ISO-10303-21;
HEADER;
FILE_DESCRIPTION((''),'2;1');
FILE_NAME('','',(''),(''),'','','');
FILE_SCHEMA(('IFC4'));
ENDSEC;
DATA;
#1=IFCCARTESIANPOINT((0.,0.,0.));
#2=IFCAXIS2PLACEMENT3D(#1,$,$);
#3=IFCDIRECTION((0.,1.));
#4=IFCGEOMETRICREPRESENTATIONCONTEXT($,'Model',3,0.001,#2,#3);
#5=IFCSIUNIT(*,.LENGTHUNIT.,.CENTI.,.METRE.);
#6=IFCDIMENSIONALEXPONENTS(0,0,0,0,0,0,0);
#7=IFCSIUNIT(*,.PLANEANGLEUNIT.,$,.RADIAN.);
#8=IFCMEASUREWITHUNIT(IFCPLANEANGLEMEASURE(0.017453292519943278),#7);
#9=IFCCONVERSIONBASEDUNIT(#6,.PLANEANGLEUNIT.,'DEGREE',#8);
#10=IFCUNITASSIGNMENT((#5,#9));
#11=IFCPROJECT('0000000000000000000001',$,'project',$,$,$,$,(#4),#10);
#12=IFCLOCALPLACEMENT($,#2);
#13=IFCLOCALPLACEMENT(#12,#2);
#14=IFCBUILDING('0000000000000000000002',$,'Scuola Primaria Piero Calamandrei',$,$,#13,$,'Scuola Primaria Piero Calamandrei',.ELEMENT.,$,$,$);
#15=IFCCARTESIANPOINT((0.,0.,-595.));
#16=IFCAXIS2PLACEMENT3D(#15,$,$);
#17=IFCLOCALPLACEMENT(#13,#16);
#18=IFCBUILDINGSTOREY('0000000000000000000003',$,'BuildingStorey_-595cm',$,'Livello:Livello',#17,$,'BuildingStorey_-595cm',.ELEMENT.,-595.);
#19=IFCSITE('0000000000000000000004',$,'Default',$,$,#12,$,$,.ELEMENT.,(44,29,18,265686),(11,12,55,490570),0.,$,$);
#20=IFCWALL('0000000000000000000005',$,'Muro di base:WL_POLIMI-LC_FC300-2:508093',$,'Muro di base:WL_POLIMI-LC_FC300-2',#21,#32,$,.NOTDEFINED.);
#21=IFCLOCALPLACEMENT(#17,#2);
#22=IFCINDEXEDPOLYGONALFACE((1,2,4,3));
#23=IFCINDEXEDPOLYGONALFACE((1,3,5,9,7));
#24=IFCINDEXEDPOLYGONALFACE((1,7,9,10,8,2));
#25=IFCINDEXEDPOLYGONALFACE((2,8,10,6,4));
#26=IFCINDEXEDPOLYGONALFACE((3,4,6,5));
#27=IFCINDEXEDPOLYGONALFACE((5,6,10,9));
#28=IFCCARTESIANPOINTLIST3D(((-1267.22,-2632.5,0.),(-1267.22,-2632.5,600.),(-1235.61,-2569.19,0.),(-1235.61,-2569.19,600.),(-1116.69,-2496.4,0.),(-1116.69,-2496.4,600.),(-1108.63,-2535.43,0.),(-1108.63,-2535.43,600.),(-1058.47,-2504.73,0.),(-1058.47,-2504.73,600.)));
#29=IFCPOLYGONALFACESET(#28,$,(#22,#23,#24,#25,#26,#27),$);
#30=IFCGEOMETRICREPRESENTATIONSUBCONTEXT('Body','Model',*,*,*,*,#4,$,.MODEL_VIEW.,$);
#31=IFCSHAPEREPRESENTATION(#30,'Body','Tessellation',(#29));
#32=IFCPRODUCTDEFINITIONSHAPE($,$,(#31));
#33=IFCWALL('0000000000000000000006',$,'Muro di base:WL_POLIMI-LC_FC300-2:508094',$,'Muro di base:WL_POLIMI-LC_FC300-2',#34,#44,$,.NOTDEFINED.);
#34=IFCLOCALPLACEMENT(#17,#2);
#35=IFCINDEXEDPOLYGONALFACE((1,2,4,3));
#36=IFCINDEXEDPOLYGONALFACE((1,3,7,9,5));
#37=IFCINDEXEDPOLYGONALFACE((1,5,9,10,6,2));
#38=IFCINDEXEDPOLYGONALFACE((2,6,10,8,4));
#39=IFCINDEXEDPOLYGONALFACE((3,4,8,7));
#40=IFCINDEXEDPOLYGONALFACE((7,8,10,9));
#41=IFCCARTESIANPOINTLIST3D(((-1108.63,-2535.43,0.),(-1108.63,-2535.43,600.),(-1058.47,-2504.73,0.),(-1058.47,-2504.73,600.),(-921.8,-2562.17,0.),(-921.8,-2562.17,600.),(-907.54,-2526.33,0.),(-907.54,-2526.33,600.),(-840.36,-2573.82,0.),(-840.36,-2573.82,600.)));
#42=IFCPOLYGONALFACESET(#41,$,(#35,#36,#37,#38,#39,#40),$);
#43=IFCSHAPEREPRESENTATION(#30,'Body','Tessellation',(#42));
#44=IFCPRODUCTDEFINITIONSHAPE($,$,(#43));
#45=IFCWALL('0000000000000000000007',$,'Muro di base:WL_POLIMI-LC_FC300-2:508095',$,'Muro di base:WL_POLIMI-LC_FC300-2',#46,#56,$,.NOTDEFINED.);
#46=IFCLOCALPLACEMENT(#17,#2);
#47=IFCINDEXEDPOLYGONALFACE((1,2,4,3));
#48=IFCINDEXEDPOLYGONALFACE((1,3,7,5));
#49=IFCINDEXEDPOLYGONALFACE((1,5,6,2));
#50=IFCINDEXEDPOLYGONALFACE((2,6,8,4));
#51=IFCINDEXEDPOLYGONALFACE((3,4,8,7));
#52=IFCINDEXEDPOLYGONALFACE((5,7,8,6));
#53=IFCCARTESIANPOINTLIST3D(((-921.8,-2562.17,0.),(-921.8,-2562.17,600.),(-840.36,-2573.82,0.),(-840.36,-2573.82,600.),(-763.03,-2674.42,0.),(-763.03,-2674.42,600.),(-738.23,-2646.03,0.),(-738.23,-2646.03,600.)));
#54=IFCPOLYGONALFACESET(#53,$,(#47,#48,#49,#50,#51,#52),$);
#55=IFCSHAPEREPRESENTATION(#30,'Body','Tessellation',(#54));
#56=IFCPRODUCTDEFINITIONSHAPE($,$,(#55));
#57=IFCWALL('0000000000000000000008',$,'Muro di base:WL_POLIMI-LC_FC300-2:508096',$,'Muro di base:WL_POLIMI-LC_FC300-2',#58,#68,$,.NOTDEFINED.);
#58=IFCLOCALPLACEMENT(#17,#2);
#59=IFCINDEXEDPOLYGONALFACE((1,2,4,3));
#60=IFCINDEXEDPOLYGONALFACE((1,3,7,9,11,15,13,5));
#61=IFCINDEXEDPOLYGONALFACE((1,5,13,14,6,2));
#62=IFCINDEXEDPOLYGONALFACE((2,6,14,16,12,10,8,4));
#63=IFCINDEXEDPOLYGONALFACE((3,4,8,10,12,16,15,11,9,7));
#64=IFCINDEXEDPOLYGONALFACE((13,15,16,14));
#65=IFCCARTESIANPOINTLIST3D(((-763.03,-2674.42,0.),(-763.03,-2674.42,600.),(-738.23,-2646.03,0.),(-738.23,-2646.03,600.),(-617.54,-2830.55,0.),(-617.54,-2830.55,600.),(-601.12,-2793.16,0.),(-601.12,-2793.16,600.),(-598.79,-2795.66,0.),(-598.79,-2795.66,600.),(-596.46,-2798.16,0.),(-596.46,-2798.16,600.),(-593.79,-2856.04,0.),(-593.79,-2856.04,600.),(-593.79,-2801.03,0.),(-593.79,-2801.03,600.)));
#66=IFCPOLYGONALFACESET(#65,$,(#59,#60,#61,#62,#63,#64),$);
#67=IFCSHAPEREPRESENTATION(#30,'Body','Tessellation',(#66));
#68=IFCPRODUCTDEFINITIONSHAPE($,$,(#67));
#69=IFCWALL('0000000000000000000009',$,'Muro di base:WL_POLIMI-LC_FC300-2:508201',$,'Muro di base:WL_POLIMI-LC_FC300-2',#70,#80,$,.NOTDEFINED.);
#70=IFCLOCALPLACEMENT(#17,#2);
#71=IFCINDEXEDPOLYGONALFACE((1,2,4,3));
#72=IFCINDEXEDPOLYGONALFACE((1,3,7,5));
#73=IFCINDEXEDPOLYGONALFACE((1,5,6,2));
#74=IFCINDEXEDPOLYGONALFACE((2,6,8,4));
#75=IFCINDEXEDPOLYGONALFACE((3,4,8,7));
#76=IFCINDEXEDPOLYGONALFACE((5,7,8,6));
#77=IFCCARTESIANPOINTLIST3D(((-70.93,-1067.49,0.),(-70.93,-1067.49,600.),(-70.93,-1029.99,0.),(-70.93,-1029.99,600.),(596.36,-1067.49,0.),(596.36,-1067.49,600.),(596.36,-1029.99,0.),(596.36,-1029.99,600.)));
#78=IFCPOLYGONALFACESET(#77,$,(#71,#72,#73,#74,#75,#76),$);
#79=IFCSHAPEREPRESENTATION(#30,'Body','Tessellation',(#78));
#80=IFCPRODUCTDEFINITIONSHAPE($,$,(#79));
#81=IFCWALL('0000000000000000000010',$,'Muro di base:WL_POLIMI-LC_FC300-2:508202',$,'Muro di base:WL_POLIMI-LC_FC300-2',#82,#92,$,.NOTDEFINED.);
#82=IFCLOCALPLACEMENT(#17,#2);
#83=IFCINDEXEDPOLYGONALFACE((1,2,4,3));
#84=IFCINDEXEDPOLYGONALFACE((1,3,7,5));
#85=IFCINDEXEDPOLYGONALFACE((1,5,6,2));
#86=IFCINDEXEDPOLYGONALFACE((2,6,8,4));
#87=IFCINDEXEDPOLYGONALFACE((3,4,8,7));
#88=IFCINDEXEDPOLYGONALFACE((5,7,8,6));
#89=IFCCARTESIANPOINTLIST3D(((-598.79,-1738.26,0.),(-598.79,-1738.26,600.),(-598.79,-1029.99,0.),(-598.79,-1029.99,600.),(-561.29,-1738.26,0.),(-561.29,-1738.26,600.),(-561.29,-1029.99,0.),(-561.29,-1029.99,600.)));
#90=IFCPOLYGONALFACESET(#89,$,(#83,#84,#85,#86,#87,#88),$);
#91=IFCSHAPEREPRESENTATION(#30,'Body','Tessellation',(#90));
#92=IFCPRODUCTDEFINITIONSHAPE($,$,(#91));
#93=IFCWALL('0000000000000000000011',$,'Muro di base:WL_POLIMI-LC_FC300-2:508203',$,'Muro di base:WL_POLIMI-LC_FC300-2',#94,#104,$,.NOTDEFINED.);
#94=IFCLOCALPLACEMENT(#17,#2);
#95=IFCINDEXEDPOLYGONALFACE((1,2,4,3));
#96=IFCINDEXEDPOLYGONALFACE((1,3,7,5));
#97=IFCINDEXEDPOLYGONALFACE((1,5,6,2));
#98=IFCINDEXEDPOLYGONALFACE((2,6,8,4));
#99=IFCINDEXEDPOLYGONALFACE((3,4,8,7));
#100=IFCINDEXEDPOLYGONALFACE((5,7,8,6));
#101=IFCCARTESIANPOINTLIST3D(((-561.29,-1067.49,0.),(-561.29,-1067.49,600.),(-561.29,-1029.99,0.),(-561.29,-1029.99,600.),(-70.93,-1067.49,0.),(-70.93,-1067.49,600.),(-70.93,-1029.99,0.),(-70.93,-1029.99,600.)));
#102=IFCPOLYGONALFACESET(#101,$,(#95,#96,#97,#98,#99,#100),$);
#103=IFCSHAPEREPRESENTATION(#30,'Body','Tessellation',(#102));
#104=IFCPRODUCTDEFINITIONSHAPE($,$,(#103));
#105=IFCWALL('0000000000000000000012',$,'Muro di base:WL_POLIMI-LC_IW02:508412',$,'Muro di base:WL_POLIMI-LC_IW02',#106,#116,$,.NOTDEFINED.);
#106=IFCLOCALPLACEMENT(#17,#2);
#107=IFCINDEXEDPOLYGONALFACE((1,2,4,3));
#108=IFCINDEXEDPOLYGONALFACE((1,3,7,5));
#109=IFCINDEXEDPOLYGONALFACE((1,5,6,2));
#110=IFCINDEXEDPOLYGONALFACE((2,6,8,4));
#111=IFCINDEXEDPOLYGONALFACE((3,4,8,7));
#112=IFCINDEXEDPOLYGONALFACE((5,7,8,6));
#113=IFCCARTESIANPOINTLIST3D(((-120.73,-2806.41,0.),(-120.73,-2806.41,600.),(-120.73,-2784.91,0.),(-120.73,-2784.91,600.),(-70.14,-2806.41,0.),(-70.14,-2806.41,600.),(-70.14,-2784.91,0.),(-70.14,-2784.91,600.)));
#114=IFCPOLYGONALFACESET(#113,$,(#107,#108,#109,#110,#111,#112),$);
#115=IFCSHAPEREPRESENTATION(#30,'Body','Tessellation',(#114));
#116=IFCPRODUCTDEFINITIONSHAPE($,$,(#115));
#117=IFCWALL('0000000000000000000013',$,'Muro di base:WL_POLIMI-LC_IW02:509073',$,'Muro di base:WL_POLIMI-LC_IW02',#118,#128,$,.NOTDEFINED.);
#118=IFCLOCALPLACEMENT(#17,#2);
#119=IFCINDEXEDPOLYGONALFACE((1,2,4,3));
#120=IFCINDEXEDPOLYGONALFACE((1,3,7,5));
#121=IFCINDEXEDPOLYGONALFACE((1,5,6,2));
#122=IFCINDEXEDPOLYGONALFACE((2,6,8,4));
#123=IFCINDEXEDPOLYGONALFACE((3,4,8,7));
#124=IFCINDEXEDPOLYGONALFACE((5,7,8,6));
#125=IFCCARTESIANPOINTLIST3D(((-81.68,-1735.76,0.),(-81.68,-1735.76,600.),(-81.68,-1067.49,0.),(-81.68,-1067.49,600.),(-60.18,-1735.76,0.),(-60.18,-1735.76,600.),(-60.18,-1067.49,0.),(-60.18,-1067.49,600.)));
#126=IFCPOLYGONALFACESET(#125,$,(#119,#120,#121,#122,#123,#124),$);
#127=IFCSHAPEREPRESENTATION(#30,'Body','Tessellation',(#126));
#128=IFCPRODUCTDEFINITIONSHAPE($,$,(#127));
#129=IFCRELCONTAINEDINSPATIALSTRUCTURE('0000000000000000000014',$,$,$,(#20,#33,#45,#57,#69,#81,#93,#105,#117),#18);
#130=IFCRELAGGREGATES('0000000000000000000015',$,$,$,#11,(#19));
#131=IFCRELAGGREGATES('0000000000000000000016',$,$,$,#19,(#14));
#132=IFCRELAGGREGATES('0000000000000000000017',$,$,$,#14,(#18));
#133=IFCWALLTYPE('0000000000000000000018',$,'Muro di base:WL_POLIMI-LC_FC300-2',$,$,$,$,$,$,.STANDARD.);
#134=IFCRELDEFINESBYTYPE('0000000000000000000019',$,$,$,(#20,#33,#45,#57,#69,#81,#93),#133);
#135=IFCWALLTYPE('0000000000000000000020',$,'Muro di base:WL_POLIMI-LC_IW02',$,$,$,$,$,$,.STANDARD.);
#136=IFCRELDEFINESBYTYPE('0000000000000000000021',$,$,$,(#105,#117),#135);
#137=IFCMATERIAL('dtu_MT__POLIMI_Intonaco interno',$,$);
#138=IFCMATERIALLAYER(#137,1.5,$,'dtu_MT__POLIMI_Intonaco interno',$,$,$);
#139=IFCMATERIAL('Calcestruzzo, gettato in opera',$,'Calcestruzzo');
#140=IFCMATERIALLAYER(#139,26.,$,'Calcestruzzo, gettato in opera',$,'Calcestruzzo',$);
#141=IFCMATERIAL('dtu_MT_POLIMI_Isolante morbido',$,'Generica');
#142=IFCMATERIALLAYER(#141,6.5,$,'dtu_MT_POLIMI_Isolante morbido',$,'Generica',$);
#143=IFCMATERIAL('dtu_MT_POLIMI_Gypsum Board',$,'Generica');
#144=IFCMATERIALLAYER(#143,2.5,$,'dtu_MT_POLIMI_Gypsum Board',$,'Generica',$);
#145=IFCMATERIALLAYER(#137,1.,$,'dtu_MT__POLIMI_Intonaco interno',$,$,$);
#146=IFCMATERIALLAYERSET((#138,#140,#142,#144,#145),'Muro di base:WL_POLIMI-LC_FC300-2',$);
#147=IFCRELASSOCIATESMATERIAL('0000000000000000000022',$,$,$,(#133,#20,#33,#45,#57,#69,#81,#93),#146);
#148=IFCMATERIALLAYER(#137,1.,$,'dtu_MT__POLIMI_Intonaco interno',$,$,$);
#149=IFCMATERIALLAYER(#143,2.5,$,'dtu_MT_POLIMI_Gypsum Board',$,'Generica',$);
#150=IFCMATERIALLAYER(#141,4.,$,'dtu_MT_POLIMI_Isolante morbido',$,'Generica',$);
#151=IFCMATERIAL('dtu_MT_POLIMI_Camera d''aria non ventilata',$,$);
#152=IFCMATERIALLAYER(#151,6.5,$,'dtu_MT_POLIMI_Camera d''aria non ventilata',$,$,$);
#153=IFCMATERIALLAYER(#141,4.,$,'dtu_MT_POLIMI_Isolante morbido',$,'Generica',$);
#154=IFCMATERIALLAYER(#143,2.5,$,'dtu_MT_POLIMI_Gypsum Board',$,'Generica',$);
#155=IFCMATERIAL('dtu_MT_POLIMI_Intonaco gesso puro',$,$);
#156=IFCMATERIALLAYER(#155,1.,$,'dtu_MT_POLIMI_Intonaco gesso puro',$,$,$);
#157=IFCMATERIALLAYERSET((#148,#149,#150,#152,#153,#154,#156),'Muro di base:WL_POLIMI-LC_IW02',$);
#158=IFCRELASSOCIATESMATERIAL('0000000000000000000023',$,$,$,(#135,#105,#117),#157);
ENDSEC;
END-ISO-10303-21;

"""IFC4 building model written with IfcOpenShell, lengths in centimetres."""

from ifc_helpers import new_model, entity, si_unit, converted_unit, direction, frame, frame_2d, origin, place, context, subcontext, project, spatial, polyline, rectangle, outline, extrude, material, layer, layer_set, layer_usage, type_object, element, save


model = new_model("IFC4")

# Units and contexts
model_context = context("Model", 3, precision=0.001, world=origin(), true_north=direction((0.0, 1.0)))
body_context = subcontext(model_context, "Body", "Model", "MODEL_VIEW")
ifc_project = project(units=[si_unit("LENGTHUNIT", "METRE", prefix="CENTI"), converted_unit("PLANEANGLEUNIT", "DEGREE", entity("IfcPlaneAngleMeasure", 0.017453292519943278), si_unit("PLANEANGLEUNIT", "RADIAN"), dimensions=[0, 0, 0, 0, 0, 0, 0])], contexts=[model_context])

# Site, building, storey
site_placement = place(None, origin())
site = spatial("IfcSite", under=ifc_project, at=site_placement, Name="Default", CompositionType="ELEMENT", RefLatitude=(44, 29, 18, 265686), RefLongitude=(11, 12, 55, 490570), RefElevation=0.0)
building_placement = place(site_placement, origin())
building = spatial("IfcBuilding", under=site, at=building_placement, Name="Scuola Primaria Piero Calamandrei", LongName="Scuola Primaria Piero Calamandrei", CompositionType="ELEMENT")
storey_placement = place(building_placement, frame((0.0, 0.0, -595.0)))
storey = spatial("IfcBuildingStorey", under=building, at=storey_placement, Name="BuildingStorey_-595cm", ObjectType="Livello:Livello", LongName="BuildingStorey_-595cm", CompositionType="ELEMENT", Elevation=-595.0)

# Walls
ifc_material_1 = material(Name="dtu_MT__POLIMI_Intonaco interno")
ifc_layer_1 = layer(ifc_material_1, 1.5, Name="dtu_MT__POLIMI_Intonaco interno")
ifc_material_2 = material(Name="Calcestruzzo, gettato in opera", Category="Calcestruzzo")
ifc_layer_2 = layer(ifc_material_2, 26.0, Name="Calcestruzzo, gettato in opera", Category="Calcestruzzo")
ifc_material_3 = material(Name="dtu_MT_POLIMI_Isolante morbido", Category="Generica")
ifc_layer_3 = layer(ifc_material_3, 6.5, Name="dtu_MT_POLIMI_Isolante morbido", Category="Generica")
ifc_material_4 = material(Name="dtu_MT_POLIMI_Gypsum Board", Category="Generica")
ifc_layer_4 = layer(ifc_material_4, 2.5, Name="dtu_MT_POLIMI_Gypsum Board", Category="Generica")
ifc_layer_5 = layer(ifc_material_1, 1.0, Name="dtu_MT__POLIMI_Intonaco interno")
ifc_layer_set_1 = layer_set([ifc_layer_1, ifc_layer_2, ifc_layer_3, ifc_layer_4, ifc_layer_5], Name="Muro di base:WL_POLIMI-LC_FC300-2")
wall_type_1 = type_object("IfcWallType", Name="Muro di base:WL_POLIMI-LC_FC300-2", PredefinedType="STANDARD", material=ifc_layer_set_1)
ifc_layer_usage_1 = layer_usage(ifc_layer_set_1, "AXIS2", "NEGATIVE", 18.75)
wall_1_placement = place(storey_placement, frame((-1277.0, -2616.51, 0.0), z_axis=(0.0, 0.0, 1.0), x_axis=(0.85291, 0.522058, 0.0)))
element("IfcWall", 1, at=wall_1_placement, inside=storey, type_object=wall_type_1, material=ifc_layer_usage_1, Name="Muro di base:WL_POLIMI-LC_FC300-2:508093", ObjectType="Muro di base:WL_POLIMI-LC_FC300-2", PredefinedType="NOTDEFINED", context=body_context, shape_type="SweptSolid", body=[
    extrude(outline(polyline([(244.74, -18.75), (199.44, 18.75), (60.01, 18.75), (0.0, -18.75), (185.93, -18.75), (244.74, -18.75)])), origin(), (0.0, 0.0, 1.0), 600.0),
])
ifc_layer_usage_2 = layer_usage(ifc_layer_set_1, "AXIS2", "NEGATIVE", 18.75)
wall_2_placement = place(storey_placement, frame((-1105.98, -2516.87, 0.0), z_axis=(0.0, 0.0, 1.0), x_axis=(0.989918, -0.141644, 0.0)))
element("IfcWall", 2, at=wall_2_placement, inside=storey, type_object=wall_type_1, material=ifc_layer_usage_2, Name="Muro di base:WL_POLIMI-LC_FC300-2:508094", ObjectType="Muro di base:WL_POLIMI-LC_FC300-2", PredefinedType="NOTDEFINED", context=body_context, shape_type="SweptSolid", body=[
    extrude(outline(polyline([(271.0, -18.75), (197.78, 18.75), (45.31, 18.75), (0.0, -18.75), (188.73, -18.75), (271.0, -18.75)])), origin(), (0.0, 0.0, 1.0), 600.0),
])
ifc_layer_usage_3 = layer_usage(ifc_layer_set_1, "AXIS2", "NEGATIVE", 18.75)
wall_3_placement = place(storey_placement, frame((-910.98, -2546.86, 0.0), z_axis=(0.0, 0.0, 1.0), x_axis=(0.816533, -0.577299, 0.0)))
element("IfcWall", 3, at=wall_3_placement, inside=storey, type_object=wall_type_1, material=ifc_layer_usage_3, Name="Muro di base:WL_POLIMI-LC_FC300-2:508095", ObjectType="Muro di base:WL_POLIMI-LC_FC300-2", PredefinedType="NOTDEFINED", context=body_context, shape_type="SweptSolid", body=[
    extrude(outline(polyline([(194.45, -18.75), (198.31, 18.75), (73.23, 18.75), (0.0, -18.75), (194.45, -18.75)])), origin(), (0.0, 0.0, 1.0), 600.0),
])
ifc_layer_usage_4 = layer_usage(ifc_layer_set_1, "AXIS2", "NEGATIVE", 18.75)
wall_4_placement = place(storey_placement, frame((-751.94, -2658.81, 0.0), z_axis=(0.0, 0.0, 1.0), x_axis=(0.681735, -0.731599, 0.0)))
element("IfcWall", 4, at=wall_4_placement, inside=storey, type_object=wall_type_1, material=ifc_layer_usage_4, Name="Muro di base:WL_POLIMI-LC_FC300-2:508096", ObjectType="Muro di base:WL_POLIMI-LC_FC300-2", PredefinedType="NOTDEFINED", context=body_context, shape_type="SweptSolid", body=[
    extrude(outline(polyline([(252.11, -18.75), (211.86, 18.75), (207.95, 18.75), (204.53, 18.75), (201.11, 18.75), (0.0, 18.75), (3.86, -18.75), (217.27, -18.75), (252.11, -18.75)])), origin(), (0.0, 0.0, 1.0), 600.0),
])
ifc_layer_usage_5 = layer_usage(ifc_layer_set_1, "AXIS2", "NEGATIVE", 18.75)
wall_5_placement = place(storey_placement, frame((-70.93, -1048.74, 0.0)))
element("IfcWall", 5, at=wall_5_placement, inside=storey, type_object=wall_type_1, material=ifc_layer_usage_5, Name="Muro di base:WL_POLIMI-LC_FC300-2:508201", ObjectType="Muro di base:WL_POLIMI-LC_FC300-2", PredefinedType="NOTDEFINED", context=body_context, shape_type="SweptSolid", body=[
    extrude(rectangle(XDim=667.29, YDim=37.5, at=frame_2d((333.65, 0.0), x_axis=(-1.0, 0.0))), origin(), (0.0, 0.0, 1.0), 600.0),
])
ifc_layer_usage_6 = layer_usage(ifc_layer_set_1, "AXIS2", "NEGATIVE", 18.75)
wall_6_placement = place(storey_placement, frame((-580.04, -1738.26, 0.0), z_axis=(0.0, 0.0, 1.0), x_axis=(0.0, 1.0, 0.0)))
element("IfcWall", 6, at=wall_6_placement, inside=storey, type_object=wall_type_1, material=ifc_layer_usage_6, Name="Muro di base:WL_POLIMI-LC_FC300-2:508202", ObjectType="Muro di base:WL_POLIMI-LC_FC300-2", PredefinedType="NOTDEFINED", context=body_context, shape_type="SweptSolid", body=[
    extrude(rectangle(XDim=708.26, YDim=37.5, at=frame_2d((354.13, 0.0), x_axis=(-1.0, 0.0))), origin(), (0.0, 0.0, 1.0), 600.0),
])
ifc_layer_usage_7 = layer_usage(ifc_layer_set_1, "AXIS2", "NEGATIVE", 18.75)
wall_7_placement = place(storey_placement, frame((-561.29, -1048.74, 0.0)))
element("IfcWall", 7, at=wall_7_placement, inside=storey, type_object=wall_type_1, material=ifc_layer_usage_7, Name="Muro di base:WL_POLIMI-LC_FC300-2:508203", ObjectType="Muro di base:WL_POLIMI-LC_FC300-2", PredefinedType="NOTDEFINED", context=body_context, shape_type="SweptSolid", body=[
    extrude(rectangle(XDim=490.36, YDim=37.5, at=frame_2d((245.18, 0.0), x_axis=(-1.0, 0.0))), origin(), (0.0, 0.0, 1.0), 600.0),
])
ifc_layer_6 = layer(ifc_material_1, 1.0, Name="dtu_MT__POLIMI_Intonaco interno")
ifc_layer_7 = layer(ifc_material_4, 2.5, Name="dtu_MT_POLIMI_Gypsum Board", Category="Generica")
ifc_layer_8 = layer(ifc_material_3, 4.0, Name="dtu_MT_POLIMI_Isolante morbido", Category="Generica")
ifc_material_5 = material(Name="dtu_MT_POLIMI_Camera d'aria non ventilata")
ifc_layer_9 = layer(ifc_material_5, 6.5, Name="dtu_MT_POLIMI_Camera d'aria non ventilata")
ifc_layer_10 = layer(ifc_material_3, 4.0, Name="dtu_MT_POLIMI_Isolante morbido", Category="Generica")
ifc_layer_11 = layer(ifc_material_4, 2.5, Name="dtu_MT_POLIMI_Gypsum Board", Category="Generica")
ifc_material_6 = material(Name="dtu_MT_POLIMI_Intonaco gesso puro")
ifc_layer_12 = layer(ifc_material_6, 1.0, Name="dtu_MT_POLIMI_Intonaco gesso puro")
ifc_layer_set_2 = layer_set([ifc_layer_6, ifc_layer_7, ifc_layer_8, ifc_layer_9, ifc_layer_10, ifc_layer_11, ifc_layer_12], Name="Muro di base:WL_POLIMI-LC_IW02")
ifc_layer_usage_8 = layer_usage(ifc_layer_set_2, "AXIS2", "NEGATIVE", 10.75)
wall_type_2 = type_object("IfcWallType", Name="Muro di base:WL_POLIMI-LC_IW02", PredefinedType="STANDARD", material=ifc_layer_set_2)
wall_8_placement = place(storey_placement, frame((-120.73, -2795.66, 0.0)))
element("IfcWall", 8, at=wall_8_placement, inside=storey, type_object=wall_type_2, material=ifc_layer_usage_8, Name="Muro di base:WL_POLIMI-LC_IW02:508412", ObjectType="Muro di base:WL_POLIMI-LC_IW02", PredefinedType="NOTDEFINED", context=body_context, shape_type="SweptSolid", body=[
    extrude(rectangle(XDim=50.59, YDim=21.5, at=frame_2d((25.29, 0.0), x_axis=(-1.0, 0.0))), origin(), (0.0, 0.0, 1.0), 600.0),
])
ifc_layer_usage_9 = layer_usage(ifc_layer_set_2, "AXIS2", "NEGATIVE", 10.75)
wall_9_placement = place(storey_placement, frame((-70.93, -1735.76, 0.0), z_axis=(0.0, 0.0, 1.0), x_axis=(0.0, 1.0, 0.0)))
element("IfcWall", 9, at=wall_9_placement, inside=storey, type_object=wall_type_2, material=ifc_layer_usage_9, Name="Muro di base:WL_POLIMI-LC_IW02:509073", ObjectType="Muro di base:WL_POLIMI-LC_IW02", PredefinedType="NOTDEFINED", context=body_context, shape_type="SweptSolid", body=[
    extrude(rectangle(XDim=668.26, YDim=21.5, at=frame_2d((334.13, 0.0), x_axis=(-1.0, 0.0))), origin(), (0.0, 0.0, 1.0), 600.0),
])

save(model, "model.ifc")
